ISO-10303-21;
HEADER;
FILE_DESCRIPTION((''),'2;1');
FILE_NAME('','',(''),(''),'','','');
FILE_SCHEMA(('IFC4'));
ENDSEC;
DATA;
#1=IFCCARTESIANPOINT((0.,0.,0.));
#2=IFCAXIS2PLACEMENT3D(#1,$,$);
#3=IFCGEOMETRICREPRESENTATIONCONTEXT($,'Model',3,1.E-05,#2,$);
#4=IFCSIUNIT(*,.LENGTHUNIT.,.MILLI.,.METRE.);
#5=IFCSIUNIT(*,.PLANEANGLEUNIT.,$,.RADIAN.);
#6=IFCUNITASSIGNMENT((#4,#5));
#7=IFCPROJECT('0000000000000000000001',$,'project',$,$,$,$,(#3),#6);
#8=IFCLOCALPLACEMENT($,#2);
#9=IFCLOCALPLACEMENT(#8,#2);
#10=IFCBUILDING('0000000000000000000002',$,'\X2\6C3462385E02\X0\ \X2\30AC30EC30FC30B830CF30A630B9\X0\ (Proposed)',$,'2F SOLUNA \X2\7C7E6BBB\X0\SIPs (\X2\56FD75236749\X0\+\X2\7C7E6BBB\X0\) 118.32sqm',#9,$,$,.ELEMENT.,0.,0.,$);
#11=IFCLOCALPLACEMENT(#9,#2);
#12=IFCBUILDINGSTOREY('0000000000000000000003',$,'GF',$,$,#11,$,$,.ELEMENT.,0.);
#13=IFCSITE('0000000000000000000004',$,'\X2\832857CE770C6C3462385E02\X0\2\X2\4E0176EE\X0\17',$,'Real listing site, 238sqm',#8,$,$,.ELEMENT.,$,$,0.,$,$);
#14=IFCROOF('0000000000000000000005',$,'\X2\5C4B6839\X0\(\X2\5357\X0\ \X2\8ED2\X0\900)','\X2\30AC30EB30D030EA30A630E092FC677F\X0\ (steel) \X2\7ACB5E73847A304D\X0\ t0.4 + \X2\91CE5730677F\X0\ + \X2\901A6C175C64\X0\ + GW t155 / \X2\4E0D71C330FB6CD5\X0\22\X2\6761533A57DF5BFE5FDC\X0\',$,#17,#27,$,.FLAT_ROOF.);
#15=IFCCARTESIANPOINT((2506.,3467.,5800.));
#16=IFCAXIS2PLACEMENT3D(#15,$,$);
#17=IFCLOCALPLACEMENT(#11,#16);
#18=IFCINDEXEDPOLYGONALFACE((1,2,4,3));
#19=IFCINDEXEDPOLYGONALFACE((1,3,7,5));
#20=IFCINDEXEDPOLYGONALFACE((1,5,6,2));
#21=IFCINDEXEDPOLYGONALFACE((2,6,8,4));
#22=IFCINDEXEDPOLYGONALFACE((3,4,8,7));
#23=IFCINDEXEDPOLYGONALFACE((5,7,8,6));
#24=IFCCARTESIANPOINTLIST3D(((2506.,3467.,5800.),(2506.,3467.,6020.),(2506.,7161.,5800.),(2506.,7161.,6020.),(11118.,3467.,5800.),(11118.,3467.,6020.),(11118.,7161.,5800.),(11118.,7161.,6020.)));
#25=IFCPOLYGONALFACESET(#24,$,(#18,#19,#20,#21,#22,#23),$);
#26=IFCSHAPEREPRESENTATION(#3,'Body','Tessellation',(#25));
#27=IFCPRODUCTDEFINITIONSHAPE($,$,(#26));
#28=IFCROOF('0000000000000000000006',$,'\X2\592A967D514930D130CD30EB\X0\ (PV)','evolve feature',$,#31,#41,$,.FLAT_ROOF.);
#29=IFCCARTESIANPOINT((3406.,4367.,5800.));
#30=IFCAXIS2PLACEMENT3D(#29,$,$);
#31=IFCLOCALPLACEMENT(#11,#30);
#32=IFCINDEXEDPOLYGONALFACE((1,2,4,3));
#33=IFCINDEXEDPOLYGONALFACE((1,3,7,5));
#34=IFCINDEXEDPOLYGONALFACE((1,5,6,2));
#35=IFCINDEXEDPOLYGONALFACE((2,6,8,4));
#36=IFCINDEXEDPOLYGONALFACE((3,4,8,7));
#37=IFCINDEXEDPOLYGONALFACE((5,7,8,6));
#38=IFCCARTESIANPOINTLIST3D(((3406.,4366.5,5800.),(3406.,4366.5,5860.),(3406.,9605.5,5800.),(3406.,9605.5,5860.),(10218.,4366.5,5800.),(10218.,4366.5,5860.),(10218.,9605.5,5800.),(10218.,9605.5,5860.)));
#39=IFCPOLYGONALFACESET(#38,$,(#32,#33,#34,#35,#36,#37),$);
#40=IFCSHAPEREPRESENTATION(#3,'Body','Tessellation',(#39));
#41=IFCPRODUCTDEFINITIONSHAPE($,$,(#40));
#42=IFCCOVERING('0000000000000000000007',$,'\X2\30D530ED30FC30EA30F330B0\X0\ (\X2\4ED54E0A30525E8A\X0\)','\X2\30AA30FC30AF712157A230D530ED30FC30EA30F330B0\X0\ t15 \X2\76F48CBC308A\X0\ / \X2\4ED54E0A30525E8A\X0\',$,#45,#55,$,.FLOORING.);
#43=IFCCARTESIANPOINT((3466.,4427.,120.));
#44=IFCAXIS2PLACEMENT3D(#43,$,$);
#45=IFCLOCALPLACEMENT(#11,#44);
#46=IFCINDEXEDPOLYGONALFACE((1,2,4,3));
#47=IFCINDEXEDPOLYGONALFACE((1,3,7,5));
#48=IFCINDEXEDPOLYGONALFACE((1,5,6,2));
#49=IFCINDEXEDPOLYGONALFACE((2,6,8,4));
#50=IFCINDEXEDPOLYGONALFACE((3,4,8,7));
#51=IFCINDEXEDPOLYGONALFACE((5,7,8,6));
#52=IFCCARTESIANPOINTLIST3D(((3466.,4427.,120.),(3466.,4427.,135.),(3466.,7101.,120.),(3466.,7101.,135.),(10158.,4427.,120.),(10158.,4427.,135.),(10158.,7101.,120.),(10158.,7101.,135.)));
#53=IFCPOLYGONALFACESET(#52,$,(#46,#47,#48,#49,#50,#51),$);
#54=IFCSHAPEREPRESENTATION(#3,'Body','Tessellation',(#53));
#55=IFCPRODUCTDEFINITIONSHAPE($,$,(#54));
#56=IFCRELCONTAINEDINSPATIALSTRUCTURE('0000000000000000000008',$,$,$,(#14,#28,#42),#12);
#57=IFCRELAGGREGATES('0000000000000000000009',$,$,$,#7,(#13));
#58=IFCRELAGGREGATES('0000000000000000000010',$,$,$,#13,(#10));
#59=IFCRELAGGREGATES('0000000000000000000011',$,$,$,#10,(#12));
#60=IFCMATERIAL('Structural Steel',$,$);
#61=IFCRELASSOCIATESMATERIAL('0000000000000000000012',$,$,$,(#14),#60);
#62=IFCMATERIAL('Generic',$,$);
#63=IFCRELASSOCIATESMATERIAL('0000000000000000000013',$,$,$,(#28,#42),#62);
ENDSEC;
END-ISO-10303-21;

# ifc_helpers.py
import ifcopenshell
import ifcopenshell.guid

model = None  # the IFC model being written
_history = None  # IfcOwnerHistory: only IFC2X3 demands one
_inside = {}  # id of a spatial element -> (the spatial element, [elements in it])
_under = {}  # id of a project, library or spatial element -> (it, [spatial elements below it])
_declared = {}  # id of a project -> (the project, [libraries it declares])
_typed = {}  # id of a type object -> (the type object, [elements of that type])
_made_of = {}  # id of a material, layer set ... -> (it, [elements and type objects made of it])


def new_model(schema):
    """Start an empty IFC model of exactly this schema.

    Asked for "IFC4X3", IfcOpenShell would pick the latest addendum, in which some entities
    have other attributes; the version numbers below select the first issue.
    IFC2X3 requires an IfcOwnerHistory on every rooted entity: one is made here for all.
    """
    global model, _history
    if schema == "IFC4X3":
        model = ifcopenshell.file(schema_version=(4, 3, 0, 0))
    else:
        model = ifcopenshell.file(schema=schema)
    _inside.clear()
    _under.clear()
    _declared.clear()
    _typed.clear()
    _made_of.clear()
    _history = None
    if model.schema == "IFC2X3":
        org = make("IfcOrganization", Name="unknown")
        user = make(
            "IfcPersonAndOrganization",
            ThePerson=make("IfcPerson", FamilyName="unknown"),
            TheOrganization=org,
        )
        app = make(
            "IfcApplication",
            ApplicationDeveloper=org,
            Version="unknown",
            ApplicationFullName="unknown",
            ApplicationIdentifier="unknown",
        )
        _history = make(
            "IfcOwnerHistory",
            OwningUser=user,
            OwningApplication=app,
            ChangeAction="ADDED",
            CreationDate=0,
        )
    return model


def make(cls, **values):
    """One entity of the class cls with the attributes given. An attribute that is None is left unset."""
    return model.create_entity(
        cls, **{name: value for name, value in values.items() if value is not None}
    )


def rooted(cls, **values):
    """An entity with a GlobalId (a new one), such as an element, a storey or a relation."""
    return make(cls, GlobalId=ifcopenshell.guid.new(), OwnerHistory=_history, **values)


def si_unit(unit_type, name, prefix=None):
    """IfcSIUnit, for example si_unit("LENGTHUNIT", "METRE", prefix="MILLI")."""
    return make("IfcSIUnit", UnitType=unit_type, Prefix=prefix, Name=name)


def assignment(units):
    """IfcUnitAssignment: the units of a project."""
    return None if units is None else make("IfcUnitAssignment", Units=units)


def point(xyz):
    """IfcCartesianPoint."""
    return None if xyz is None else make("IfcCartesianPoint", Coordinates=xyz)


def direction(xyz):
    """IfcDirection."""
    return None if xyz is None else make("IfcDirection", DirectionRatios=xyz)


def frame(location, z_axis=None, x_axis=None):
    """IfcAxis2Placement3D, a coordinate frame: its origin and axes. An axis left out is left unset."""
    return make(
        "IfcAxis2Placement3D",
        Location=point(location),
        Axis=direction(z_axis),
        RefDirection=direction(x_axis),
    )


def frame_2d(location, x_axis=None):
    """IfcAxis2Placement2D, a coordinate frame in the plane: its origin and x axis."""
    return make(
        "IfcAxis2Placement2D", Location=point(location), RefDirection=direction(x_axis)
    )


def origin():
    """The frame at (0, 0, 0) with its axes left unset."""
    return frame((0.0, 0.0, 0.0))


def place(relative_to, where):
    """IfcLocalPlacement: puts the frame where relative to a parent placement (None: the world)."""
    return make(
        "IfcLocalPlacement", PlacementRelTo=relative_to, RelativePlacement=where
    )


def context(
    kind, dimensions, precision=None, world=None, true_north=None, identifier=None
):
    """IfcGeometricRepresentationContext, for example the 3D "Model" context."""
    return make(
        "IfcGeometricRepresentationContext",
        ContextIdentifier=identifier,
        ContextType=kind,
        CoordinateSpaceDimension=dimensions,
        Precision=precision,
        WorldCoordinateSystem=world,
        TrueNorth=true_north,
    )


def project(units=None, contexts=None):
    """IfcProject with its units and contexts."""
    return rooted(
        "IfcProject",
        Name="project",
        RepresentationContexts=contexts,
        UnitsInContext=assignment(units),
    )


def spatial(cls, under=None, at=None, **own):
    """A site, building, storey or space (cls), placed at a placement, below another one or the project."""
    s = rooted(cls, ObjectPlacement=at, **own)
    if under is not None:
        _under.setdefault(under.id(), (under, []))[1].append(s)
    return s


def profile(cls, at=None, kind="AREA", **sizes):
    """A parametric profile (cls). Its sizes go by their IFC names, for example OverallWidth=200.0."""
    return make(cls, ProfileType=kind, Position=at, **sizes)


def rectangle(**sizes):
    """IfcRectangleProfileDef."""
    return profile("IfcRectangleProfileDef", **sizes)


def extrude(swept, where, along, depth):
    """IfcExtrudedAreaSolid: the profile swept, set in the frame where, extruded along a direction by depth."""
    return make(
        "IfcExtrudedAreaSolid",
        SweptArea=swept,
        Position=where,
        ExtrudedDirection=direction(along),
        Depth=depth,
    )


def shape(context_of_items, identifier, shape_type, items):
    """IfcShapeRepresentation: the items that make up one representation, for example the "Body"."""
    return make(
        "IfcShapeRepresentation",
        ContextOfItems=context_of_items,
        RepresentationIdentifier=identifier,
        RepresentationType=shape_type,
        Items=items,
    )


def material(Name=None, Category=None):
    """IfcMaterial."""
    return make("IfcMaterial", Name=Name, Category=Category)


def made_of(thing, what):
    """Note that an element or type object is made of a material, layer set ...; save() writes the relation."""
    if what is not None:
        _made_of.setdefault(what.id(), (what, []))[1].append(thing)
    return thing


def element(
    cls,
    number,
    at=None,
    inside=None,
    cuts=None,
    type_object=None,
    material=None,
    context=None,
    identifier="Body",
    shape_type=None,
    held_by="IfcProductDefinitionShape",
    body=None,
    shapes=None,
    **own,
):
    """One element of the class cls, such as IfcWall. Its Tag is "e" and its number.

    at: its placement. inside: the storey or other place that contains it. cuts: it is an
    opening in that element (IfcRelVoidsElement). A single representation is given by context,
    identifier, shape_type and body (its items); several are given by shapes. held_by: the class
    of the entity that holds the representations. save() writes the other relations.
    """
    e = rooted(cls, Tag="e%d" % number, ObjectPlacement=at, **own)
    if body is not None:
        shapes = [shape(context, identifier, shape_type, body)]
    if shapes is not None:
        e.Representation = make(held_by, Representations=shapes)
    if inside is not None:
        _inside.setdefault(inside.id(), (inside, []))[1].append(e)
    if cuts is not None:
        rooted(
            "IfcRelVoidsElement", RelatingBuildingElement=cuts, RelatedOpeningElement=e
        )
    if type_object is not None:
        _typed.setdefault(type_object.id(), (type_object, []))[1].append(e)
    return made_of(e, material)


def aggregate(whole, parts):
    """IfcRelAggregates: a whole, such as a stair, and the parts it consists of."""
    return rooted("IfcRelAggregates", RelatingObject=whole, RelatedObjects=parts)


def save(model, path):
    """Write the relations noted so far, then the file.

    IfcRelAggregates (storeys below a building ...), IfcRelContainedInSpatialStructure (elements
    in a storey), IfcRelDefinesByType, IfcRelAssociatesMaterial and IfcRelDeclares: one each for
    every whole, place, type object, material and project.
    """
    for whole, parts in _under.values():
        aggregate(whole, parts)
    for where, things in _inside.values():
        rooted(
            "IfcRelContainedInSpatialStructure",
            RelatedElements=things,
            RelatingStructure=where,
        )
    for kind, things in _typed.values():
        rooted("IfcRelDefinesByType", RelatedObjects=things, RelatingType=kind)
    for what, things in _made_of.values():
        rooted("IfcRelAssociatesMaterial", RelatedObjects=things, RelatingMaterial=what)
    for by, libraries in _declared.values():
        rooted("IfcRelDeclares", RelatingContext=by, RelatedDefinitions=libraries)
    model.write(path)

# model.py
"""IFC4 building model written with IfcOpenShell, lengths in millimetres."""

from ifc_helpers import new_model, si_unit, frame, frame_2d, origin, place, context, project, spatial, rectangle, extrude, material, element, save


model = new_model("IFC4")

# Units and contexts
model_context = context("Model", 3, precision=1e-05, world=origin())
ifc_project = project(units=[si_unit("LENGTHUNIT", "METRE", prefix="MILLI"), si_unit("PLANEANGLEUNIT", "RADIAN")], contexts=[model_context])

# Site, building, storey
site_placement = place(None, origin())
site = spatial("IfcSite", under=ifc_project, at=site_placement, Name="茨城県水戸市2丁目17", ObjectType="Real listing site, 238sqm", CompositionType="ELEMENT", RefElevation=0.0)
building_placement = place(site_placement, origin())
building = spatial("IfcBuilding", under=site, at=building_placement, Name="水戸市 ガレージハウス (Proposed)", ObjectType="2F SOLUNA 籾殻SIPs (国産杉+籾殻) 118.32sqm", CompositionType="ELEMENT", ElevationOfRefHeight=0.0, ElevationOfTerrain=0.0)
storey_placement = place(building_placement, origin())
storey = spatial("IfcBuildingStorey", under=building, at=storey_placement, Name="GF", CompositionType="ELEMENT", Elevation=0.0)

# Shared definitions
ifc_material_1 = material(Name="Generic")

# Roofs
ifc_material_2 = material(Name="Structural Steel")
roof_1_placement = place(storey_placement, frame((2506.0, 3467.0, 5800.0)))
element("IfcRoof", 1, at=roof_1_placement, inside=storey, material=ifc_material_2, Name="屋根(南 軒900)", Description="ガルバリウム鋼板 (steel) 立平葺き t0.4 + 野地板 + 通気層 + GW t155 / 不燃・法22条区域対応", PredefinedType="FLAT_ROOF", context=model_context, shape_type="SweptSolid", body=[
    extrude(rectangle(XDim=8612.0, YDim=3694.0, at=frame_2d((4306.0, 1847.0))), frame((2506.0, 3467.0, 5800.0)), (0.0, 0.0, 1.0), 220.0),
])
roof_2_placement = place(storey_placement, frame((3406.0, 4367.0, 5800.0)))
element("IfcRoof", 2, at=roof_2_placement, inside=storey, material=ifc_material_1, Name="太陽光パネル (PV)", Description="evolve feature", PredefinedType="FLAT_ROOF", context=model_context, shape_type="SweptSolid", body=[
    extrude(rectangle(XDim=6812.0, YDim=5239.0, at=frame_2d((3406.0, 2619.0))), frame((3406.0, 4367.0, 5800.0)), (0.0, 0.0, 1.0), 60.0),
])

# Covering
covering_placement = place(storey_placement, frame((3466.0, 4427.0, 120.0)))
element("IfcCovering", 3, at=covering_placement, inside=storey, material=ifc_material_1, Name="フローリング (仕上げ床)", Description="オーク無垢フローリング t15 直貼り / 仕上げ床", PredefinedType="FLOORING", context=model_context, shape_type="SweptSolid", body=[
    extrude(rectangle(XDim=6692.0, YDim=2674.0, at=frame_2d((3346.0, 1337.0))), frame((3466.0, 4427.0, 120.0)), (0.0, 0.0, 1.0), 15.0),
])

save(model, "model.ifc")
